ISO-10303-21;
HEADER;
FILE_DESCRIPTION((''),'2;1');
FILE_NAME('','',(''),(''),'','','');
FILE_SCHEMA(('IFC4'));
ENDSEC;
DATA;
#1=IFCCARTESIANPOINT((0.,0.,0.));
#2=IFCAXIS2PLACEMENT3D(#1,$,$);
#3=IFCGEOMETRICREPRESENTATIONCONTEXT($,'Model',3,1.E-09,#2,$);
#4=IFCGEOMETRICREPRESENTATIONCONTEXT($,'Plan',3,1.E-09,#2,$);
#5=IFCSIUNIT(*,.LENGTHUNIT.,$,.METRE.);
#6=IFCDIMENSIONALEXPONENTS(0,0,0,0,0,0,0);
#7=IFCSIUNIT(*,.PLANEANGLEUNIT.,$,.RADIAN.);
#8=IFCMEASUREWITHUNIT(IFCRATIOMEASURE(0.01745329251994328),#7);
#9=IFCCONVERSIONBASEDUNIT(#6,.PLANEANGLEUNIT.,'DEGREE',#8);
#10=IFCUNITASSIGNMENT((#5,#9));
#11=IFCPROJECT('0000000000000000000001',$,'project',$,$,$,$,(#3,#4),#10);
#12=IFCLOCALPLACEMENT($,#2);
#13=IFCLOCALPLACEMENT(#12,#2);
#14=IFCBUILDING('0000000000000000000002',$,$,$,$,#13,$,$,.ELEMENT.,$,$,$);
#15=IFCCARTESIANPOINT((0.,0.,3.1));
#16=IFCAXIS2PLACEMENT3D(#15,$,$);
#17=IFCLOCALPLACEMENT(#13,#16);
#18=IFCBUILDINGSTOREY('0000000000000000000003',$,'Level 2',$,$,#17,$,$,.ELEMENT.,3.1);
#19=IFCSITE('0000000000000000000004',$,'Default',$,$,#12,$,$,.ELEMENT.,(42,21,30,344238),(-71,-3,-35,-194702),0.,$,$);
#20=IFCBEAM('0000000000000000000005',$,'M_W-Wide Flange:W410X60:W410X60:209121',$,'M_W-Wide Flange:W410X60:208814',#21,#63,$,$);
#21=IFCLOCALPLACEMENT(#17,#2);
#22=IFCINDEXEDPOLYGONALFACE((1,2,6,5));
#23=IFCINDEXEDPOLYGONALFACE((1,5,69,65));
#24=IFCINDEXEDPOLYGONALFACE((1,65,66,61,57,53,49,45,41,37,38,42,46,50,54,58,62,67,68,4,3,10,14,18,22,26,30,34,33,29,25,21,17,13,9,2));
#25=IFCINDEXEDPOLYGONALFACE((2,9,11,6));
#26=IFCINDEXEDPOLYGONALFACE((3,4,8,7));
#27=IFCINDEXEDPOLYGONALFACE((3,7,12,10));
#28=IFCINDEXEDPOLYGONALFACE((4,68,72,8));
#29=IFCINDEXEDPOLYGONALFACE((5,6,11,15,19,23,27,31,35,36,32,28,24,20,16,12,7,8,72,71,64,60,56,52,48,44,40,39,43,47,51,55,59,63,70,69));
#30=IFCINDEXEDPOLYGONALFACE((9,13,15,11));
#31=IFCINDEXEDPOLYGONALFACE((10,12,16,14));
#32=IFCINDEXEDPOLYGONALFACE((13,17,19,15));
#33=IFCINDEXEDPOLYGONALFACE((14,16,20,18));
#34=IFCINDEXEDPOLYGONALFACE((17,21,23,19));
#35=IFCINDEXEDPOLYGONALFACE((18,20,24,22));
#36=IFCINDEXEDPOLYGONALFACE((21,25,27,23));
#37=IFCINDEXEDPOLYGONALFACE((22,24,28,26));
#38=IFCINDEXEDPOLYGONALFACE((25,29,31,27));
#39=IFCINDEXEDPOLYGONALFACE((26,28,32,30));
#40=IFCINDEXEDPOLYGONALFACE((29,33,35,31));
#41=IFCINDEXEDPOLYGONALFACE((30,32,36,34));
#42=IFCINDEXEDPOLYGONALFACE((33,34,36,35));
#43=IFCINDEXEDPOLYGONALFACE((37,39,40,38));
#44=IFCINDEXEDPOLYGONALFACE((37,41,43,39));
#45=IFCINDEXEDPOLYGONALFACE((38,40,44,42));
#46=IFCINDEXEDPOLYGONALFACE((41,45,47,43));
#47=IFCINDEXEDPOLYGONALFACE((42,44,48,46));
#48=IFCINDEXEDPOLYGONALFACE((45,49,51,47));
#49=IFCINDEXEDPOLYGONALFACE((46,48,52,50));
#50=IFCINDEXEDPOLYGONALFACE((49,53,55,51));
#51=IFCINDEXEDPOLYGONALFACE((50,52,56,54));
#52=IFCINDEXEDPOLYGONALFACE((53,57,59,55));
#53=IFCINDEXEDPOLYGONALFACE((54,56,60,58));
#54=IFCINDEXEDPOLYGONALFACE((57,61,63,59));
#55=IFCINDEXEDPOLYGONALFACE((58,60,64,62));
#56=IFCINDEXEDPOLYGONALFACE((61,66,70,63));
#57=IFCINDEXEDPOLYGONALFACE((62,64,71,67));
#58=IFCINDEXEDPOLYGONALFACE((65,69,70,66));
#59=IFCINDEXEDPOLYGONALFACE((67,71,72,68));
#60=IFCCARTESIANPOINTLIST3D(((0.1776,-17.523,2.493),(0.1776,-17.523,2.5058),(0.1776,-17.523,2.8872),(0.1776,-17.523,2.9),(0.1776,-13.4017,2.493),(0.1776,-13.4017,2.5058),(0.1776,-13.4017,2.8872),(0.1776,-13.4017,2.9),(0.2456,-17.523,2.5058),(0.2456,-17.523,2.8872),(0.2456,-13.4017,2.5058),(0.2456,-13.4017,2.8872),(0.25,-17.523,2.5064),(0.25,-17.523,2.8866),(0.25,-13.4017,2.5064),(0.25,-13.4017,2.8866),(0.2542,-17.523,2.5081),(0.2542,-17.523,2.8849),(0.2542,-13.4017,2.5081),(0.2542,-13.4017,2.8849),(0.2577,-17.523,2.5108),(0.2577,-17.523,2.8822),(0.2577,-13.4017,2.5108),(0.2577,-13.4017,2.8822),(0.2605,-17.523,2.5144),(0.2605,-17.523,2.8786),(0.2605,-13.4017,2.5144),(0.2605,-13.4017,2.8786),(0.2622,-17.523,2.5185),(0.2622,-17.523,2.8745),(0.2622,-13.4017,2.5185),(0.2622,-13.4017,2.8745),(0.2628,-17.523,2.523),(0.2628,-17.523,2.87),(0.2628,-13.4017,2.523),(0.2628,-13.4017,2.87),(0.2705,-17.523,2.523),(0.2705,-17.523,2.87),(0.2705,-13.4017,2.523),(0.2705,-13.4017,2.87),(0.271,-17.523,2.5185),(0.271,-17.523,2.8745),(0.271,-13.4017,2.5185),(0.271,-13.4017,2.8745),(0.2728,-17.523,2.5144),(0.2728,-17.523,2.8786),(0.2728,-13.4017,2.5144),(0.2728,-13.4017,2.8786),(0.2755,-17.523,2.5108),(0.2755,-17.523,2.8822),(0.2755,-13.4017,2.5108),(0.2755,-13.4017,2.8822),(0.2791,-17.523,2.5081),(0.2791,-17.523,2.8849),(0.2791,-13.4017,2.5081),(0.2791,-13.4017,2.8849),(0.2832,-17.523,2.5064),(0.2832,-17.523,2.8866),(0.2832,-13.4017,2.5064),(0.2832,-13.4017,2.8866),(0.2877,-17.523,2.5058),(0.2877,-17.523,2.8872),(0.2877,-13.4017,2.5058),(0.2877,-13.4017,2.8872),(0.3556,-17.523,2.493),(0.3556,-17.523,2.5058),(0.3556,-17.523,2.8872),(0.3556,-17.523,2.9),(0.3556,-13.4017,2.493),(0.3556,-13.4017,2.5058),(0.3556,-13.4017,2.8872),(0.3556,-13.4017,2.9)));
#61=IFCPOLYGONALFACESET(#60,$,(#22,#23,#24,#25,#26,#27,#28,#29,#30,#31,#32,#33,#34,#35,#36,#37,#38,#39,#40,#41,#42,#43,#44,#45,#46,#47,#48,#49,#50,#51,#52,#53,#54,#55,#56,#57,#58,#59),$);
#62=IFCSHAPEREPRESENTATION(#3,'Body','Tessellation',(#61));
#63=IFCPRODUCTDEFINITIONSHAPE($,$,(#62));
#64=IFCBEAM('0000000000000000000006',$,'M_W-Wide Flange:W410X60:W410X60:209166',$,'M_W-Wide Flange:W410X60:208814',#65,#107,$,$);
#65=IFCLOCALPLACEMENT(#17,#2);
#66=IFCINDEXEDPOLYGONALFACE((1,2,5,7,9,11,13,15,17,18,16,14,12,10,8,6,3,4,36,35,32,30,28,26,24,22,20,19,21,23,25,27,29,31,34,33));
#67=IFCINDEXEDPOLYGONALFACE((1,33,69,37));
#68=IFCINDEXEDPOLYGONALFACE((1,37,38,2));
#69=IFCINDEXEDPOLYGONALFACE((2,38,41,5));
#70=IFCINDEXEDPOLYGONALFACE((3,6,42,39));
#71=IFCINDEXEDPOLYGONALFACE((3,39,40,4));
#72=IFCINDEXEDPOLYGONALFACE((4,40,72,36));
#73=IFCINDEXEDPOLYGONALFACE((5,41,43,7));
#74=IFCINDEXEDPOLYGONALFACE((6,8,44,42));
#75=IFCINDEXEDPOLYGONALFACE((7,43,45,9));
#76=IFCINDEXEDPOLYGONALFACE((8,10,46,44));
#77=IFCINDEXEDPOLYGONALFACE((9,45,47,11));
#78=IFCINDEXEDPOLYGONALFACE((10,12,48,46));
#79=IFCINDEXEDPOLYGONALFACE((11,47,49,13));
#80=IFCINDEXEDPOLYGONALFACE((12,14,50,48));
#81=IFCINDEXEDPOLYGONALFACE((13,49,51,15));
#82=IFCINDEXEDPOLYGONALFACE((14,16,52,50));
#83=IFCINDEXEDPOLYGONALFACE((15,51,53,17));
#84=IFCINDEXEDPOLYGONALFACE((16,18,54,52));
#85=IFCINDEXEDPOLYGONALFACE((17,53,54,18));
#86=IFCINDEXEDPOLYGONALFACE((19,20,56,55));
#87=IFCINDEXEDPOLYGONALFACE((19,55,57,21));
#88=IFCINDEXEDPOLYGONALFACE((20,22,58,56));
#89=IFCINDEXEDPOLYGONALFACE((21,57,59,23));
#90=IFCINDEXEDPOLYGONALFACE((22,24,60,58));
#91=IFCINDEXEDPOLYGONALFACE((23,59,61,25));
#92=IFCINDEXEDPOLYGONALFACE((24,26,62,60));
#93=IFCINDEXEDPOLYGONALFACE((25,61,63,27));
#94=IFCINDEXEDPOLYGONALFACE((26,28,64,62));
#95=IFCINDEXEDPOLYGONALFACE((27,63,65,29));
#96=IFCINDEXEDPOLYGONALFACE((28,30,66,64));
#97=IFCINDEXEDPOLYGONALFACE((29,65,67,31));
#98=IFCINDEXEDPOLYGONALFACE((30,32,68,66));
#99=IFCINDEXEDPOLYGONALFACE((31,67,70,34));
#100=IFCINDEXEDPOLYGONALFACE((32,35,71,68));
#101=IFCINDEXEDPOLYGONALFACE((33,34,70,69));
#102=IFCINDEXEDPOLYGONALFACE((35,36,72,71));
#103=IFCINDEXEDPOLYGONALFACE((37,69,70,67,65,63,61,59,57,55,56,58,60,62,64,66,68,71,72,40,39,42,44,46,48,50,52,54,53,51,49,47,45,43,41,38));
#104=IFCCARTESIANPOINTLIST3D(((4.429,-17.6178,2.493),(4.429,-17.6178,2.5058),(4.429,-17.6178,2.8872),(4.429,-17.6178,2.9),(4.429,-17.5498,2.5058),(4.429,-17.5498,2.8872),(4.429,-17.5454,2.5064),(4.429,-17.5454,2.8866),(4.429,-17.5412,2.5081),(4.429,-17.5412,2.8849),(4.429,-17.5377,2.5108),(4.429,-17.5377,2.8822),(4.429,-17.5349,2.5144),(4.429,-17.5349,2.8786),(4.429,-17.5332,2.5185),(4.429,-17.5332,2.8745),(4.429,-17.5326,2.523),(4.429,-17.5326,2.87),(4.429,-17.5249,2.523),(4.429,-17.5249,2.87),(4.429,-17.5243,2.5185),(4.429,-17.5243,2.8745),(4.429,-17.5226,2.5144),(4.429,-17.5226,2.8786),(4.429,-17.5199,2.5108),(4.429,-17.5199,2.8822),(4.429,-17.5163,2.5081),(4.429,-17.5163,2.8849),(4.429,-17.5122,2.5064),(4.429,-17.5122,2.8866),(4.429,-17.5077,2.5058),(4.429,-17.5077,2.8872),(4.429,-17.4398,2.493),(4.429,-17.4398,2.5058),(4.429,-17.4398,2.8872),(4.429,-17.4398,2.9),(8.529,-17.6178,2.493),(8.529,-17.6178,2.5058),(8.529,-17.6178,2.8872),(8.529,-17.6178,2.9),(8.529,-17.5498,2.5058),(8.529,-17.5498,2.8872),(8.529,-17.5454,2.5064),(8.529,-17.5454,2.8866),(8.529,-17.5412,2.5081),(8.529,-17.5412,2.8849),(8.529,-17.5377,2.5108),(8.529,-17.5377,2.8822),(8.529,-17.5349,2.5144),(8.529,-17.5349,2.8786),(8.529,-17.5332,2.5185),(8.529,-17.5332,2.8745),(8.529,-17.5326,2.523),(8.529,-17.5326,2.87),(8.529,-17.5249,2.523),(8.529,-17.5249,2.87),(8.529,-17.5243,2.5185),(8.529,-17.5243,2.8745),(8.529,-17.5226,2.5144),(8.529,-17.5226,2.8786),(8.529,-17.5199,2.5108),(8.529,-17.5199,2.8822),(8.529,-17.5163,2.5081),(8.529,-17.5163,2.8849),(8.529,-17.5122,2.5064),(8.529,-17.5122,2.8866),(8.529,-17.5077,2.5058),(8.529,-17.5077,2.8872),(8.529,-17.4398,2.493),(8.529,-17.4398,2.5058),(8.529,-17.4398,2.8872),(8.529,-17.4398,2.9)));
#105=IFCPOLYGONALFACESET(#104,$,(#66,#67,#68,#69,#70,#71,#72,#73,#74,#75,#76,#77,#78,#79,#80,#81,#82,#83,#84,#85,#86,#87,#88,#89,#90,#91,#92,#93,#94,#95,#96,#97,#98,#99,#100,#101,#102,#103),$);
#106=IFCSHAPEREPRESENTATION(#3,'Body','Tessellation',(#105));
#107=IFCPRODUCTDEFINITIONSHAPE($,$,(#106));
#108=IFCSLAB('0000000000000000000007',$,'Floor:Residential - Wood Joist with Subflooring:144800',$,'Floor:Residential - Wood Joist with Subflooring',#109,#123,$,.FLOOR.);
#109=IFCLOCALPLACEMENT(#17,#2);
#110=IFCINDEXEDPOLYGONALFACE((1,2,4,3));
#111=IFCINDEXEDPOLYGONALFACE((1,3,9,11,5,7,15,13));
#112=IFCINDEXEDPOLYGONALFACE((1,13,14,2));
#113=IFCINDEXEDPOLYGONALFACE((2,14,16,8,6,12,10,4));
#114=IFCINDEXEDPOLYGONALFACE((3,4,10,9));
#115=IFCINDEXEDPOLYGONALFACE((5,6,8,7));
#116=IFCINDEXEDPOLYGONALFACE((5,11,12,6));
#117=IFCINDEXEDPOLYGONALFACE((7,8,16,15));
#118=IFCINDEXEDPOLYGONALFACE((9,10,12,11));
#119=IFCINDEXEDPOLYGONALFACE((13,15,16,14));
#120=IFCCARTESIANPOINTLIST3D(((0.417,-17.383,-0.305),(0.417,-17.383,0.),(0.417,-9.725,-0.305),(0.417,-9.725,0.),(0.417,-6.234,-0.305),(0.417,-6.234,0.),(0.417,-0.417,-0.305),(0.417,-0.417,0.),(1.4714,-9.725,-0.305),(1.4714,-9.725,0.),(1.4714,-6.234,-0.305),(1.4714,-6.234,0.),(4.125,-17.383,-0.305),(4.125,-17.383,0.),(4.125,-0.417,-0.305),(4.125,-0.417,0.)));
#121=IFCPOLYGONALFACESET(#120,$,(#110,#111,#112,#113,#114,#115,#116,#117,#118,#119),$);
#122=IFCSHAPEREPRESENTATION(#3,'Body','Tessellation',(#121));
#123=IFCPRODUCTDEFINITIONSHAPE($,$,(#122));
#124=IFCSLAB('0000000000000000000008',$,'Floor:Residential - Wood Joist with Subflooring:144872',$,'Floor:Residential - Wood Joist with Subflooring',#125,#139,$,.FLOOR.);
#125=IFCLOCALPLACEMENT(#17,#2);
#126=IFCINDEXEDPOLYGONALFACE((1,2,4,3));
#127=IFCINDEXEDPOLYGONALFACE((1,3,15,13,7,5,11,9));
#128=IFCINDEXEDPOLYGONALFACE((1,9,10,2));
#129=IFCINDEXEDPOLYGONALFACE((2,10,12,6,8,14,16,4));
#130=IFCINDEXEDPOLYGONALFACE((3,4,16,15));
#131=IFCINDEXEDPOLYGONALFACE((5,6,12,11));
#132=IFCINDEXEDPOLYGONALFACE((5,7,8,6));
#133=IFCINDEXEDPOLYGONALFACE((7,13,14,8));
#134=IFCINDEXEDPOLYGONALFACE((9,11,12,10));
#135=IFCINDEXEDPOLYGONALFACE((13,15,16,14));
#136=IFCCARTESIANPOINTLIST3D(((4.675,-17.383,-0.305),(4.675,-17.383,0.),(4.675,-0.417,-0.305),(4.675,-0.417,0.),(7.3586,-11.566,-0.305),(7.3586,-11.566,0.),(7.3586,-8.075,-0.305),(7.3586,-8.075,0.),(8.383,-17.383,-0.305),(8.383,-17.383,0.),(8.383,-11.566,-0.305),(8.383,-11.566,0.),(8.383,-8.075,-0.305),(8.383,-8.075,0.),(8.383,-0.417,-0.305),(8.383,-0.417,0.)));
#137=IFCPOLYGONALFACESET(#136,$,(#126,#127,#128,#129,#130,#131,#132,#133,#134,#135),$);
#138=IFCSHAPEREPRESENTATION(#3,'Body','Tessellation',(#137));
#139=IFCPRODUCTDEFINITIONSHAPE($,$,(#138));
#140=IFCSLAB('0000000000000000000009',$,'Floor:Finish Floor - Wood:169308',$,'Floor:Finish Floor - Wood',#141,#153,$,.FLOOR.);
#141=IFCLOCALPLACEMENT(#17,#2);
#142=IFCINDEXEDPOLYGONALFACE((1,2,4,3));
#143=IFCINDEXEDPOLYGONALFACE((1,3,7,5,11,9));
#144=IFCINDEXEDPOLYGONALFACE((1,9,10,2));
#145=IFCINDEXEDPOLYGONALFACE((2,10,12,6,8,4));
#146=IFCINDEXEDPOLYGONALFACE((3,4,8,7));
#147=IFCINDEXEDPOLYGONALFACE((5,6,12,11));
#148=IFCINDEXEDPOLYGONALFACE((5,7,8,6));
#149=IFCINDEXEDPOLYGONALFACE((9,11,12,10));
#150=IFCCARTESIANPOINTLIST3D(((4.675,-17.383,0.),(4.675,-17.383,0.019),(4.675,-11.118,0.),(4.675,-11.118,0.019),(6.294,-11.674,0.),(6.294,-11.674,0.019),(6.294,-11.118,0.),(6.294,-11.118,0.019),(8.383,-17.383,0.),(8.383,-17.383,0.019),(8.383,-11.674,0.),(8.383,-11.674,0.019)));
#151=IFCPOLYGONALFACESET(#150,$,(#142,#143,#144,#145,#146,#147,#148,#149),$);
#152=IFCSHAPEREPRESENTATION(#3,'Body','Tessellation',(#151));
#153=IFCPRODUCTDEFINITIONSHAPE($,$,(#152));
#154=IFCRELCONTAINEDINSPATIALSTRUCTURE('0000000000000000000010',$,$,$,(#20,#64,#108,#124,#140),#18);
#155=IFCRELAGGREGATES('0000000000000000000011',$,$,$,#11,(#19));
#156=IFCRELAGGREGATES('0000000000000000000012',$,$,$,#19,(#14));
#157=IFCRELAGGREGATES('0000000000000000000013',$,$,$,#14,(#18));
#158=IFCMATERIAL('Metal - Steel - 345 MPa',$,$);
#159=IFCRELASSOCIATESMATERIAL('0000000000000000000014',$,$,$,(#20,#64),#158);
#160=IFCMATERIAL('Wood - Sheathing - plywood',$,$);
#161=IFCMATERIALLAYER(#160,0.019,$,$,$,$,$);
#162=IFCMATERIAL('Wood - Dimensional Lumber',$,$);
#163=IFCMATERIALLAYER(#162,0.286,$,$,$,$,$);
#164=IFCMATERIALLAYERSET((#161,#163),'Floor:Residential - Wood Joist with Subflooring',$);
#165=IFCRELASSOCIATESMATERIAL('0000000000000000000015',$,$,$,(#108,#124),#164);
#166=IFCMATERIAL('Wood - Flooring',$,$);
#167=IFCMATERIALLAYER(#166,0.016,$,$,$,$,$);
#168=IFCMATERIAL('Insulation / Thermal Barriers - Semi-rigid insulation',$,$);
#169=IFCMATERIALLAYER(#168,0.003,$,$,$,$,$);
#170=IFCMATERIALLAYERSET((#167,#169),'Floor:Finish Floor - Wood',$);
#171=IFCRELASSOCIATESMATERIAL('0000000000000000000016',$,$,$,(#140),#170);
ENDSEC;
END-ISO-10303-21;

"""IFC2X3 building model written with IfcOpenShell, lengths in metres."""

from ifc_helpers import new_model, entity, si_unit, converted_unit, frame, frame_2d, origin, place, context, project, spatial, polyline, circle_curve, parameter, trimmed, segment, composite_curve, outline, extrude, material, layer, layer_set, layer_usage, element, save


model = new_model("IFC2X3")

# Units and contexts
model_context = context("Model", 3, precision=1e-09, world=origin())
plan_context = context("Plan", 3, precision=1e-09, world=origin())
ifc_project = project(units=[si_unit("LENGTHUNIT", "METRE"), converted_unit("PLANEANGLEUNIT", "DEGREE", entity("IfcRatioMeasure", 0.01745329251994328), si_unit("PLANEANGLEUNIT", "RADIAN"), dimensions=[0, 0, 0, 0, 0, 0, 0])], contexts=[model_context, plan_context])

# Site, building, storey
site_placement = place(None, origin())
site = spatial("IfcSite", under=ifc_project, at=site_placement, Name="Default", CompositionType="ELEMENT", RefLatitude=(42, 21, 30, 344238), RefLongitude=(-71, -3, -35, -194702), RefElevation=0.0)
building_placement = place(site_placement, origin())
building = spatial("IfcBuilding", under=site, at=building_placement, CompositionType="ELEMENT")
storey_placement = place(building_placement, frame((0.0, 0.0, 3.1)))
storey = spatial("IfcBuildingStorey", under=building, at=storey_placement, Name="Level 2", CompositionType="ELEMENT", Elevation=3.1)

# Beams
ifc_material_1 = material(Name="Metal - Steel - 345 MPa")
beam_1_placement = place(storey_placement, frame((0.2666, -13.4017, 2.9), z_axis=(0.0, 0.0, 1.0), x_axis=(-1.0, 0.0, 0.0)))
element("IfcBeam", 1, at=beam_1_placement, inside=storey, material=ifc_material_1, Name="M_W-Wide Flange:W410X60:W410X60:209121", ObjectType="M_W-Wide Flange:W410X60:208814", context=model_context, shape_type="SweptSolid", body=[
    extrude(outline(composite_curve([segment(polyline([(0.1907, -0.089), (0.2035, -0.089)]), True, "CONTINUOUS"), segment(polyline([(0.2035, -0.089), (0.2035, 0.089)]), True, "CONTINUOUS"), segment(polyline([(0.2035, 0.089), (0.1907, 0.089)]), True, "CONTINUOUS"), segment(polyline([(0.1907, 0.089), (0.1907, 0.021)]), True, "CONTINUOUS"), segment(trimmed(circle_curve(frame_2d((0.1735, 0.021), x_axis=(1.0, 0.0)), 0.0172), [parameter(270.0)], [parameter(360.0)], True, "PARAMETER"), False, "CONTINUOUS"), segment(polyline([(0.1735, 0.0038), (-0.1735, 0.0038)]), True, "CONTINUOUS"), segment(trimmed(circle_curve(frame_2d((-0.1735, 0.021), x_axis=(0.0, -1.0)), 0.0172), [parameter(270.0)], [parameter(360.0)], True, "PARAMETER"), False, "CONTINUOUS"), segment(polyline([(-0.1907, 0.021), (-0.1907, 0.089)]), True, "CONTINUOUS"), segment(polyline([(-0.1907, 0.089), (-0.2035, 0.089)]), True, "CONTINUOUS"), segment(polyline([(-0.2035, 0.089), (-0.2035, -0.089)]), True, "CONTINUOUS"), segment(polyline([(-0.2035, -0.089), (-0.1907, -0.089)]), True, "CONTINUOUS"), segment(polyline([(-0.1907, -0.089), (-0.1907, -0.0211)]), True, "CONTINUOUS"), segment(trimmed(circle_curve(frame_2d((-0.1735, -0.0211), x_axis=(-1.0, 0.0)), 0.0172), [parameter(270.0)], [parameter(0.0)], True, "PARAMETER"), False, "CONTINUOUS"), segment(polyline([(-0.1735, -0.0039), (0.1735, -0.0039)]), True, "CONTINUOUS"), segment(trimmed(circle_curve(frame_2d((0.1735, -0.0211), x_axis=(0.0, 1.0)), 0.0172), [parameter(270.0)], [parameter(0.0)], True, "PARAMETER"), False, "CONTINUOUS"), segment(polyline([(0.1907, -0.0211), (0.1907, -0.089)]), True, "CONTINUOUS")], self_intersect=False)), frame((0.0, 4.1213, -0.2035), z_axis=(0.0, -1.0, 0.0), x_axis=(0.0, 0.0, -1.0)), (0.0, 0.0, 1.0), 4.1213),
])
beam_2_placement = place(storey_placement, frame((4.429, -17.5288, 2.9), z_axis=(0.0, 0.0, 1.0), x_axis=(0.0, -1.0, 0.0)))
element("IfcBeam", 2, at=beam_2_placement, inside=storey, material=ifc_material_1, Name="M_W-Wide Flange:W410X60:W410X60:209166", ObjectType="M_W-Wide Flange:W410X60:208814", context=model_context, shape_type="SweptSolid", body=[
    extrude(outline(composite_curve([segment(polyline([(-0.089, -0.1907), (-0.089, -0.2035)]), True, "CONTINUOUS"), segment(polyline([(-0.089, -0.2035), (0.089, -0.2035)]), True, "CONTINUOUS"), segment(polyline([(0.089, -0.2035), (0.089, -0.1907)]), True, "CONTINUOUS"), segment(polyline([(0.089, -0.1907), (0.021, -0.1907)]), True, "CONTINUOUS"), segment(trimmed(circle_curve(frame_2d((0.021, -0.1735), x_axis=(0.0, -1.0)), 0.0172), [parameter(270.0)], [parameter(360.0)], True, "PARAMETER"), False, "CONTINUOUS"), segment(polyline([(0.0038, -0.1735), (0.0038, 0.1735)]), True, "CONTINUOUS"), segment(trimmed(circle_curve(frame_2d((0.021, 0.1735), x_axis=(-1.0, 0.0)), 0.0172), [parameter(270.0)], [parameter(360.0)], True, "PARAMETER"), False, "CONTINUOUS"), segment(polyline([(0.021, 0.1907), (0.089, 0.1907)]), True, "CONTINUOUS"), segment(polyline([(0.089, 0.1907), (0.089, 0.2035)]), True, "CONTINUOUS"), segment(polyline([(0.089, 0.2035), (-0.089, 0.2035)]), True, "CONTINUOUS"), segment(polyline([(-0.089, 0.2035), (-0.089, 0.1907)]), True, "CONTINUOUS"), segment(polyline([(-0.089, 0.1907), (-0.0211, 0.1907)]), True, "CONTINUOUS"), segment(trimmed(circle_curve(frame_2d((-0.0211, 0.1735), x_axis=(0.0, 1.0)), 0.0172), [parameter(270.0)], [parameter(0.0)], True, "PARAMETER"), False, "CONTINUOUS"), segment(polyline([(-0.0039, 0.1735), (-0.0039, -0.1735)]), True, "CONTINUOUS"), segment(trimmed(circle_curve(frame_2d((-0.0211, -0.1735), x_axis=(1.0, 0.0)), 0.0172), [parameter(270.0)], [parameter(0.0)], True, "PARAMETER"), False, "CONTINUOUS"), segment(polyline([(-0.0211, -0.1907), (-0.089, -0.1907)]), True, "CONTINUOUS")], self_intersect=False)), frame((0.0, 0.0, -0.2035), z_axis=(0.0, -1.0, 0.0), x_axis=(1.0, 0.0, 0.0)), (0.0, 0.0, -1.0), 4.1),
])

# Slabs
ifc_material_2 = material(Name="Wood - Sheathing - plywood")
ifc_layer_1 = layer(ifc_material_2, 0.019)
ifc_material_3 = material(Name="Wood - Dimensional Lumber")
ifc_layer_2 = layer(ifc_material_3, 0.286)
ifc_layer_set_1 = layer_set([ifc_layer_1, ifc_layer_2], Name="Floor:Residential - Wood Joist with Subflooring")
ifc_layer_usage_1 = layer_usage(ifc_layer_set_1, "AXIS3", "POSITIVE", 0.0)
slab_1_placement = place(storey_placement, frame((0.417, -17.383, -0.305)))
element("IfcSlab", 3, at=slab_1_placement, inside=storey, material=ifc_layer_usage_1, Name="Floor:Residential - Wood Joist with Subflooring:144800", ObjectType="Floor:Residential - Wood Joist with Subflooring", PredefinedType="FLOOR", context=model_context, shape_type="SweptSolid", body=[
    extrude(outline(polyline([(-1.854, 8.483), (-1.854, -8.483), (1.854, -8.483), (1.854, -0.825), (0.7996, -0.825), (0.7996, 2.666), (1.854, 2.666), (1.854, 8.483), (-1.854, 8.483)])), frame((1.854, 8.483, 0.305), z_axis=(0.0, 0.0, -1.0), x_axis=(-1.0, 0.0, 0.0)), (0.0, 0.0, 1.0), 0.305),
])
ifc_layer_usage_2 = layer_usage(ifc_layer_set_1, "AXIS3", "POSITIVE", 0.0)
slab_2_placement = place(storey_placement, frame((4.675, -17.383, -0.305)))
element("IfcSlab", 4, at=slab_2_placement, inside=storey, material=ifc_layer_usage_2, Name="Floor:Residential - Wood Joist with Subflooring:144872", ObjectType="Floor:Residential - Wood Joist with Subflooring", PredefinedType="FLOOR", context=model_context, shape_type="SweptSolid", body=[
    extrude(outline(polyline([(-1.854, 8.483), (-1.854, 0.825), (-0.8296, 0.825), (-0.8296, -2.666), (-1.854, -2.666), (-1.854, -8.483), (1.854, -8.483), (1.854, 8.483), (-1.854, 8.483)])), frame((1.854, 8.483, 0.305), z_axis=(0.0, 0.0, -1.0), x_axis=(-1.0, 0.0, 0.0)), (0.0, 0.0, 1.0), 0.305),
])
ifc_material_4 = material(Name="Wood - Flooring")
ifc_layer_3 = layer(ifc_material_4, 0.016)
ifc_material_5 = material(Name="Insulation / Thermal Barriers - Semi-rigid insulation")
ifc_layer_4 = layer(ifc_material_5, 0.003)
ifc_layer_set_2 = layer_set([ifc_layer_3, ifc_layer_4], Name="Floor:Finish Floor - Wood")
ifc_layer_usage_3 = layer_usage(ifc_layer_set_2, "AXIS3", "POSITIVE", 0.0)
slab_3_placement = place(storey_placement, frame((4.675, -17.383, 0.0)))
element("IfcSlab", 5, at=slab_3_placement, inside=storey, material=ifc_layer_usage_3, Name="Floor:Finish Floor - Wood:169308", ObjectType="Floor:Finish Floor - Wood", PredefinedType="FLOOR", context=model_context, shape_type="SweptSolid", body=[
    extrude(outline(polyline([(-1.854, 2.5765), (-1.854, -3.1325), (1.854, -3.1325), (1.854, 3.1325), (0.235, 3.1325), (0.235, 2.5765), (-1.854, 2.5765)])), frame((1.854, 3.1325, 0.019), z_axis=(0.0, 0.0, -1.0), x_axis=(-1.0, 0.0, 0.0)), (0.0, 0.0, 1.0), 0.019),
])

save(model, "model.ifc")
